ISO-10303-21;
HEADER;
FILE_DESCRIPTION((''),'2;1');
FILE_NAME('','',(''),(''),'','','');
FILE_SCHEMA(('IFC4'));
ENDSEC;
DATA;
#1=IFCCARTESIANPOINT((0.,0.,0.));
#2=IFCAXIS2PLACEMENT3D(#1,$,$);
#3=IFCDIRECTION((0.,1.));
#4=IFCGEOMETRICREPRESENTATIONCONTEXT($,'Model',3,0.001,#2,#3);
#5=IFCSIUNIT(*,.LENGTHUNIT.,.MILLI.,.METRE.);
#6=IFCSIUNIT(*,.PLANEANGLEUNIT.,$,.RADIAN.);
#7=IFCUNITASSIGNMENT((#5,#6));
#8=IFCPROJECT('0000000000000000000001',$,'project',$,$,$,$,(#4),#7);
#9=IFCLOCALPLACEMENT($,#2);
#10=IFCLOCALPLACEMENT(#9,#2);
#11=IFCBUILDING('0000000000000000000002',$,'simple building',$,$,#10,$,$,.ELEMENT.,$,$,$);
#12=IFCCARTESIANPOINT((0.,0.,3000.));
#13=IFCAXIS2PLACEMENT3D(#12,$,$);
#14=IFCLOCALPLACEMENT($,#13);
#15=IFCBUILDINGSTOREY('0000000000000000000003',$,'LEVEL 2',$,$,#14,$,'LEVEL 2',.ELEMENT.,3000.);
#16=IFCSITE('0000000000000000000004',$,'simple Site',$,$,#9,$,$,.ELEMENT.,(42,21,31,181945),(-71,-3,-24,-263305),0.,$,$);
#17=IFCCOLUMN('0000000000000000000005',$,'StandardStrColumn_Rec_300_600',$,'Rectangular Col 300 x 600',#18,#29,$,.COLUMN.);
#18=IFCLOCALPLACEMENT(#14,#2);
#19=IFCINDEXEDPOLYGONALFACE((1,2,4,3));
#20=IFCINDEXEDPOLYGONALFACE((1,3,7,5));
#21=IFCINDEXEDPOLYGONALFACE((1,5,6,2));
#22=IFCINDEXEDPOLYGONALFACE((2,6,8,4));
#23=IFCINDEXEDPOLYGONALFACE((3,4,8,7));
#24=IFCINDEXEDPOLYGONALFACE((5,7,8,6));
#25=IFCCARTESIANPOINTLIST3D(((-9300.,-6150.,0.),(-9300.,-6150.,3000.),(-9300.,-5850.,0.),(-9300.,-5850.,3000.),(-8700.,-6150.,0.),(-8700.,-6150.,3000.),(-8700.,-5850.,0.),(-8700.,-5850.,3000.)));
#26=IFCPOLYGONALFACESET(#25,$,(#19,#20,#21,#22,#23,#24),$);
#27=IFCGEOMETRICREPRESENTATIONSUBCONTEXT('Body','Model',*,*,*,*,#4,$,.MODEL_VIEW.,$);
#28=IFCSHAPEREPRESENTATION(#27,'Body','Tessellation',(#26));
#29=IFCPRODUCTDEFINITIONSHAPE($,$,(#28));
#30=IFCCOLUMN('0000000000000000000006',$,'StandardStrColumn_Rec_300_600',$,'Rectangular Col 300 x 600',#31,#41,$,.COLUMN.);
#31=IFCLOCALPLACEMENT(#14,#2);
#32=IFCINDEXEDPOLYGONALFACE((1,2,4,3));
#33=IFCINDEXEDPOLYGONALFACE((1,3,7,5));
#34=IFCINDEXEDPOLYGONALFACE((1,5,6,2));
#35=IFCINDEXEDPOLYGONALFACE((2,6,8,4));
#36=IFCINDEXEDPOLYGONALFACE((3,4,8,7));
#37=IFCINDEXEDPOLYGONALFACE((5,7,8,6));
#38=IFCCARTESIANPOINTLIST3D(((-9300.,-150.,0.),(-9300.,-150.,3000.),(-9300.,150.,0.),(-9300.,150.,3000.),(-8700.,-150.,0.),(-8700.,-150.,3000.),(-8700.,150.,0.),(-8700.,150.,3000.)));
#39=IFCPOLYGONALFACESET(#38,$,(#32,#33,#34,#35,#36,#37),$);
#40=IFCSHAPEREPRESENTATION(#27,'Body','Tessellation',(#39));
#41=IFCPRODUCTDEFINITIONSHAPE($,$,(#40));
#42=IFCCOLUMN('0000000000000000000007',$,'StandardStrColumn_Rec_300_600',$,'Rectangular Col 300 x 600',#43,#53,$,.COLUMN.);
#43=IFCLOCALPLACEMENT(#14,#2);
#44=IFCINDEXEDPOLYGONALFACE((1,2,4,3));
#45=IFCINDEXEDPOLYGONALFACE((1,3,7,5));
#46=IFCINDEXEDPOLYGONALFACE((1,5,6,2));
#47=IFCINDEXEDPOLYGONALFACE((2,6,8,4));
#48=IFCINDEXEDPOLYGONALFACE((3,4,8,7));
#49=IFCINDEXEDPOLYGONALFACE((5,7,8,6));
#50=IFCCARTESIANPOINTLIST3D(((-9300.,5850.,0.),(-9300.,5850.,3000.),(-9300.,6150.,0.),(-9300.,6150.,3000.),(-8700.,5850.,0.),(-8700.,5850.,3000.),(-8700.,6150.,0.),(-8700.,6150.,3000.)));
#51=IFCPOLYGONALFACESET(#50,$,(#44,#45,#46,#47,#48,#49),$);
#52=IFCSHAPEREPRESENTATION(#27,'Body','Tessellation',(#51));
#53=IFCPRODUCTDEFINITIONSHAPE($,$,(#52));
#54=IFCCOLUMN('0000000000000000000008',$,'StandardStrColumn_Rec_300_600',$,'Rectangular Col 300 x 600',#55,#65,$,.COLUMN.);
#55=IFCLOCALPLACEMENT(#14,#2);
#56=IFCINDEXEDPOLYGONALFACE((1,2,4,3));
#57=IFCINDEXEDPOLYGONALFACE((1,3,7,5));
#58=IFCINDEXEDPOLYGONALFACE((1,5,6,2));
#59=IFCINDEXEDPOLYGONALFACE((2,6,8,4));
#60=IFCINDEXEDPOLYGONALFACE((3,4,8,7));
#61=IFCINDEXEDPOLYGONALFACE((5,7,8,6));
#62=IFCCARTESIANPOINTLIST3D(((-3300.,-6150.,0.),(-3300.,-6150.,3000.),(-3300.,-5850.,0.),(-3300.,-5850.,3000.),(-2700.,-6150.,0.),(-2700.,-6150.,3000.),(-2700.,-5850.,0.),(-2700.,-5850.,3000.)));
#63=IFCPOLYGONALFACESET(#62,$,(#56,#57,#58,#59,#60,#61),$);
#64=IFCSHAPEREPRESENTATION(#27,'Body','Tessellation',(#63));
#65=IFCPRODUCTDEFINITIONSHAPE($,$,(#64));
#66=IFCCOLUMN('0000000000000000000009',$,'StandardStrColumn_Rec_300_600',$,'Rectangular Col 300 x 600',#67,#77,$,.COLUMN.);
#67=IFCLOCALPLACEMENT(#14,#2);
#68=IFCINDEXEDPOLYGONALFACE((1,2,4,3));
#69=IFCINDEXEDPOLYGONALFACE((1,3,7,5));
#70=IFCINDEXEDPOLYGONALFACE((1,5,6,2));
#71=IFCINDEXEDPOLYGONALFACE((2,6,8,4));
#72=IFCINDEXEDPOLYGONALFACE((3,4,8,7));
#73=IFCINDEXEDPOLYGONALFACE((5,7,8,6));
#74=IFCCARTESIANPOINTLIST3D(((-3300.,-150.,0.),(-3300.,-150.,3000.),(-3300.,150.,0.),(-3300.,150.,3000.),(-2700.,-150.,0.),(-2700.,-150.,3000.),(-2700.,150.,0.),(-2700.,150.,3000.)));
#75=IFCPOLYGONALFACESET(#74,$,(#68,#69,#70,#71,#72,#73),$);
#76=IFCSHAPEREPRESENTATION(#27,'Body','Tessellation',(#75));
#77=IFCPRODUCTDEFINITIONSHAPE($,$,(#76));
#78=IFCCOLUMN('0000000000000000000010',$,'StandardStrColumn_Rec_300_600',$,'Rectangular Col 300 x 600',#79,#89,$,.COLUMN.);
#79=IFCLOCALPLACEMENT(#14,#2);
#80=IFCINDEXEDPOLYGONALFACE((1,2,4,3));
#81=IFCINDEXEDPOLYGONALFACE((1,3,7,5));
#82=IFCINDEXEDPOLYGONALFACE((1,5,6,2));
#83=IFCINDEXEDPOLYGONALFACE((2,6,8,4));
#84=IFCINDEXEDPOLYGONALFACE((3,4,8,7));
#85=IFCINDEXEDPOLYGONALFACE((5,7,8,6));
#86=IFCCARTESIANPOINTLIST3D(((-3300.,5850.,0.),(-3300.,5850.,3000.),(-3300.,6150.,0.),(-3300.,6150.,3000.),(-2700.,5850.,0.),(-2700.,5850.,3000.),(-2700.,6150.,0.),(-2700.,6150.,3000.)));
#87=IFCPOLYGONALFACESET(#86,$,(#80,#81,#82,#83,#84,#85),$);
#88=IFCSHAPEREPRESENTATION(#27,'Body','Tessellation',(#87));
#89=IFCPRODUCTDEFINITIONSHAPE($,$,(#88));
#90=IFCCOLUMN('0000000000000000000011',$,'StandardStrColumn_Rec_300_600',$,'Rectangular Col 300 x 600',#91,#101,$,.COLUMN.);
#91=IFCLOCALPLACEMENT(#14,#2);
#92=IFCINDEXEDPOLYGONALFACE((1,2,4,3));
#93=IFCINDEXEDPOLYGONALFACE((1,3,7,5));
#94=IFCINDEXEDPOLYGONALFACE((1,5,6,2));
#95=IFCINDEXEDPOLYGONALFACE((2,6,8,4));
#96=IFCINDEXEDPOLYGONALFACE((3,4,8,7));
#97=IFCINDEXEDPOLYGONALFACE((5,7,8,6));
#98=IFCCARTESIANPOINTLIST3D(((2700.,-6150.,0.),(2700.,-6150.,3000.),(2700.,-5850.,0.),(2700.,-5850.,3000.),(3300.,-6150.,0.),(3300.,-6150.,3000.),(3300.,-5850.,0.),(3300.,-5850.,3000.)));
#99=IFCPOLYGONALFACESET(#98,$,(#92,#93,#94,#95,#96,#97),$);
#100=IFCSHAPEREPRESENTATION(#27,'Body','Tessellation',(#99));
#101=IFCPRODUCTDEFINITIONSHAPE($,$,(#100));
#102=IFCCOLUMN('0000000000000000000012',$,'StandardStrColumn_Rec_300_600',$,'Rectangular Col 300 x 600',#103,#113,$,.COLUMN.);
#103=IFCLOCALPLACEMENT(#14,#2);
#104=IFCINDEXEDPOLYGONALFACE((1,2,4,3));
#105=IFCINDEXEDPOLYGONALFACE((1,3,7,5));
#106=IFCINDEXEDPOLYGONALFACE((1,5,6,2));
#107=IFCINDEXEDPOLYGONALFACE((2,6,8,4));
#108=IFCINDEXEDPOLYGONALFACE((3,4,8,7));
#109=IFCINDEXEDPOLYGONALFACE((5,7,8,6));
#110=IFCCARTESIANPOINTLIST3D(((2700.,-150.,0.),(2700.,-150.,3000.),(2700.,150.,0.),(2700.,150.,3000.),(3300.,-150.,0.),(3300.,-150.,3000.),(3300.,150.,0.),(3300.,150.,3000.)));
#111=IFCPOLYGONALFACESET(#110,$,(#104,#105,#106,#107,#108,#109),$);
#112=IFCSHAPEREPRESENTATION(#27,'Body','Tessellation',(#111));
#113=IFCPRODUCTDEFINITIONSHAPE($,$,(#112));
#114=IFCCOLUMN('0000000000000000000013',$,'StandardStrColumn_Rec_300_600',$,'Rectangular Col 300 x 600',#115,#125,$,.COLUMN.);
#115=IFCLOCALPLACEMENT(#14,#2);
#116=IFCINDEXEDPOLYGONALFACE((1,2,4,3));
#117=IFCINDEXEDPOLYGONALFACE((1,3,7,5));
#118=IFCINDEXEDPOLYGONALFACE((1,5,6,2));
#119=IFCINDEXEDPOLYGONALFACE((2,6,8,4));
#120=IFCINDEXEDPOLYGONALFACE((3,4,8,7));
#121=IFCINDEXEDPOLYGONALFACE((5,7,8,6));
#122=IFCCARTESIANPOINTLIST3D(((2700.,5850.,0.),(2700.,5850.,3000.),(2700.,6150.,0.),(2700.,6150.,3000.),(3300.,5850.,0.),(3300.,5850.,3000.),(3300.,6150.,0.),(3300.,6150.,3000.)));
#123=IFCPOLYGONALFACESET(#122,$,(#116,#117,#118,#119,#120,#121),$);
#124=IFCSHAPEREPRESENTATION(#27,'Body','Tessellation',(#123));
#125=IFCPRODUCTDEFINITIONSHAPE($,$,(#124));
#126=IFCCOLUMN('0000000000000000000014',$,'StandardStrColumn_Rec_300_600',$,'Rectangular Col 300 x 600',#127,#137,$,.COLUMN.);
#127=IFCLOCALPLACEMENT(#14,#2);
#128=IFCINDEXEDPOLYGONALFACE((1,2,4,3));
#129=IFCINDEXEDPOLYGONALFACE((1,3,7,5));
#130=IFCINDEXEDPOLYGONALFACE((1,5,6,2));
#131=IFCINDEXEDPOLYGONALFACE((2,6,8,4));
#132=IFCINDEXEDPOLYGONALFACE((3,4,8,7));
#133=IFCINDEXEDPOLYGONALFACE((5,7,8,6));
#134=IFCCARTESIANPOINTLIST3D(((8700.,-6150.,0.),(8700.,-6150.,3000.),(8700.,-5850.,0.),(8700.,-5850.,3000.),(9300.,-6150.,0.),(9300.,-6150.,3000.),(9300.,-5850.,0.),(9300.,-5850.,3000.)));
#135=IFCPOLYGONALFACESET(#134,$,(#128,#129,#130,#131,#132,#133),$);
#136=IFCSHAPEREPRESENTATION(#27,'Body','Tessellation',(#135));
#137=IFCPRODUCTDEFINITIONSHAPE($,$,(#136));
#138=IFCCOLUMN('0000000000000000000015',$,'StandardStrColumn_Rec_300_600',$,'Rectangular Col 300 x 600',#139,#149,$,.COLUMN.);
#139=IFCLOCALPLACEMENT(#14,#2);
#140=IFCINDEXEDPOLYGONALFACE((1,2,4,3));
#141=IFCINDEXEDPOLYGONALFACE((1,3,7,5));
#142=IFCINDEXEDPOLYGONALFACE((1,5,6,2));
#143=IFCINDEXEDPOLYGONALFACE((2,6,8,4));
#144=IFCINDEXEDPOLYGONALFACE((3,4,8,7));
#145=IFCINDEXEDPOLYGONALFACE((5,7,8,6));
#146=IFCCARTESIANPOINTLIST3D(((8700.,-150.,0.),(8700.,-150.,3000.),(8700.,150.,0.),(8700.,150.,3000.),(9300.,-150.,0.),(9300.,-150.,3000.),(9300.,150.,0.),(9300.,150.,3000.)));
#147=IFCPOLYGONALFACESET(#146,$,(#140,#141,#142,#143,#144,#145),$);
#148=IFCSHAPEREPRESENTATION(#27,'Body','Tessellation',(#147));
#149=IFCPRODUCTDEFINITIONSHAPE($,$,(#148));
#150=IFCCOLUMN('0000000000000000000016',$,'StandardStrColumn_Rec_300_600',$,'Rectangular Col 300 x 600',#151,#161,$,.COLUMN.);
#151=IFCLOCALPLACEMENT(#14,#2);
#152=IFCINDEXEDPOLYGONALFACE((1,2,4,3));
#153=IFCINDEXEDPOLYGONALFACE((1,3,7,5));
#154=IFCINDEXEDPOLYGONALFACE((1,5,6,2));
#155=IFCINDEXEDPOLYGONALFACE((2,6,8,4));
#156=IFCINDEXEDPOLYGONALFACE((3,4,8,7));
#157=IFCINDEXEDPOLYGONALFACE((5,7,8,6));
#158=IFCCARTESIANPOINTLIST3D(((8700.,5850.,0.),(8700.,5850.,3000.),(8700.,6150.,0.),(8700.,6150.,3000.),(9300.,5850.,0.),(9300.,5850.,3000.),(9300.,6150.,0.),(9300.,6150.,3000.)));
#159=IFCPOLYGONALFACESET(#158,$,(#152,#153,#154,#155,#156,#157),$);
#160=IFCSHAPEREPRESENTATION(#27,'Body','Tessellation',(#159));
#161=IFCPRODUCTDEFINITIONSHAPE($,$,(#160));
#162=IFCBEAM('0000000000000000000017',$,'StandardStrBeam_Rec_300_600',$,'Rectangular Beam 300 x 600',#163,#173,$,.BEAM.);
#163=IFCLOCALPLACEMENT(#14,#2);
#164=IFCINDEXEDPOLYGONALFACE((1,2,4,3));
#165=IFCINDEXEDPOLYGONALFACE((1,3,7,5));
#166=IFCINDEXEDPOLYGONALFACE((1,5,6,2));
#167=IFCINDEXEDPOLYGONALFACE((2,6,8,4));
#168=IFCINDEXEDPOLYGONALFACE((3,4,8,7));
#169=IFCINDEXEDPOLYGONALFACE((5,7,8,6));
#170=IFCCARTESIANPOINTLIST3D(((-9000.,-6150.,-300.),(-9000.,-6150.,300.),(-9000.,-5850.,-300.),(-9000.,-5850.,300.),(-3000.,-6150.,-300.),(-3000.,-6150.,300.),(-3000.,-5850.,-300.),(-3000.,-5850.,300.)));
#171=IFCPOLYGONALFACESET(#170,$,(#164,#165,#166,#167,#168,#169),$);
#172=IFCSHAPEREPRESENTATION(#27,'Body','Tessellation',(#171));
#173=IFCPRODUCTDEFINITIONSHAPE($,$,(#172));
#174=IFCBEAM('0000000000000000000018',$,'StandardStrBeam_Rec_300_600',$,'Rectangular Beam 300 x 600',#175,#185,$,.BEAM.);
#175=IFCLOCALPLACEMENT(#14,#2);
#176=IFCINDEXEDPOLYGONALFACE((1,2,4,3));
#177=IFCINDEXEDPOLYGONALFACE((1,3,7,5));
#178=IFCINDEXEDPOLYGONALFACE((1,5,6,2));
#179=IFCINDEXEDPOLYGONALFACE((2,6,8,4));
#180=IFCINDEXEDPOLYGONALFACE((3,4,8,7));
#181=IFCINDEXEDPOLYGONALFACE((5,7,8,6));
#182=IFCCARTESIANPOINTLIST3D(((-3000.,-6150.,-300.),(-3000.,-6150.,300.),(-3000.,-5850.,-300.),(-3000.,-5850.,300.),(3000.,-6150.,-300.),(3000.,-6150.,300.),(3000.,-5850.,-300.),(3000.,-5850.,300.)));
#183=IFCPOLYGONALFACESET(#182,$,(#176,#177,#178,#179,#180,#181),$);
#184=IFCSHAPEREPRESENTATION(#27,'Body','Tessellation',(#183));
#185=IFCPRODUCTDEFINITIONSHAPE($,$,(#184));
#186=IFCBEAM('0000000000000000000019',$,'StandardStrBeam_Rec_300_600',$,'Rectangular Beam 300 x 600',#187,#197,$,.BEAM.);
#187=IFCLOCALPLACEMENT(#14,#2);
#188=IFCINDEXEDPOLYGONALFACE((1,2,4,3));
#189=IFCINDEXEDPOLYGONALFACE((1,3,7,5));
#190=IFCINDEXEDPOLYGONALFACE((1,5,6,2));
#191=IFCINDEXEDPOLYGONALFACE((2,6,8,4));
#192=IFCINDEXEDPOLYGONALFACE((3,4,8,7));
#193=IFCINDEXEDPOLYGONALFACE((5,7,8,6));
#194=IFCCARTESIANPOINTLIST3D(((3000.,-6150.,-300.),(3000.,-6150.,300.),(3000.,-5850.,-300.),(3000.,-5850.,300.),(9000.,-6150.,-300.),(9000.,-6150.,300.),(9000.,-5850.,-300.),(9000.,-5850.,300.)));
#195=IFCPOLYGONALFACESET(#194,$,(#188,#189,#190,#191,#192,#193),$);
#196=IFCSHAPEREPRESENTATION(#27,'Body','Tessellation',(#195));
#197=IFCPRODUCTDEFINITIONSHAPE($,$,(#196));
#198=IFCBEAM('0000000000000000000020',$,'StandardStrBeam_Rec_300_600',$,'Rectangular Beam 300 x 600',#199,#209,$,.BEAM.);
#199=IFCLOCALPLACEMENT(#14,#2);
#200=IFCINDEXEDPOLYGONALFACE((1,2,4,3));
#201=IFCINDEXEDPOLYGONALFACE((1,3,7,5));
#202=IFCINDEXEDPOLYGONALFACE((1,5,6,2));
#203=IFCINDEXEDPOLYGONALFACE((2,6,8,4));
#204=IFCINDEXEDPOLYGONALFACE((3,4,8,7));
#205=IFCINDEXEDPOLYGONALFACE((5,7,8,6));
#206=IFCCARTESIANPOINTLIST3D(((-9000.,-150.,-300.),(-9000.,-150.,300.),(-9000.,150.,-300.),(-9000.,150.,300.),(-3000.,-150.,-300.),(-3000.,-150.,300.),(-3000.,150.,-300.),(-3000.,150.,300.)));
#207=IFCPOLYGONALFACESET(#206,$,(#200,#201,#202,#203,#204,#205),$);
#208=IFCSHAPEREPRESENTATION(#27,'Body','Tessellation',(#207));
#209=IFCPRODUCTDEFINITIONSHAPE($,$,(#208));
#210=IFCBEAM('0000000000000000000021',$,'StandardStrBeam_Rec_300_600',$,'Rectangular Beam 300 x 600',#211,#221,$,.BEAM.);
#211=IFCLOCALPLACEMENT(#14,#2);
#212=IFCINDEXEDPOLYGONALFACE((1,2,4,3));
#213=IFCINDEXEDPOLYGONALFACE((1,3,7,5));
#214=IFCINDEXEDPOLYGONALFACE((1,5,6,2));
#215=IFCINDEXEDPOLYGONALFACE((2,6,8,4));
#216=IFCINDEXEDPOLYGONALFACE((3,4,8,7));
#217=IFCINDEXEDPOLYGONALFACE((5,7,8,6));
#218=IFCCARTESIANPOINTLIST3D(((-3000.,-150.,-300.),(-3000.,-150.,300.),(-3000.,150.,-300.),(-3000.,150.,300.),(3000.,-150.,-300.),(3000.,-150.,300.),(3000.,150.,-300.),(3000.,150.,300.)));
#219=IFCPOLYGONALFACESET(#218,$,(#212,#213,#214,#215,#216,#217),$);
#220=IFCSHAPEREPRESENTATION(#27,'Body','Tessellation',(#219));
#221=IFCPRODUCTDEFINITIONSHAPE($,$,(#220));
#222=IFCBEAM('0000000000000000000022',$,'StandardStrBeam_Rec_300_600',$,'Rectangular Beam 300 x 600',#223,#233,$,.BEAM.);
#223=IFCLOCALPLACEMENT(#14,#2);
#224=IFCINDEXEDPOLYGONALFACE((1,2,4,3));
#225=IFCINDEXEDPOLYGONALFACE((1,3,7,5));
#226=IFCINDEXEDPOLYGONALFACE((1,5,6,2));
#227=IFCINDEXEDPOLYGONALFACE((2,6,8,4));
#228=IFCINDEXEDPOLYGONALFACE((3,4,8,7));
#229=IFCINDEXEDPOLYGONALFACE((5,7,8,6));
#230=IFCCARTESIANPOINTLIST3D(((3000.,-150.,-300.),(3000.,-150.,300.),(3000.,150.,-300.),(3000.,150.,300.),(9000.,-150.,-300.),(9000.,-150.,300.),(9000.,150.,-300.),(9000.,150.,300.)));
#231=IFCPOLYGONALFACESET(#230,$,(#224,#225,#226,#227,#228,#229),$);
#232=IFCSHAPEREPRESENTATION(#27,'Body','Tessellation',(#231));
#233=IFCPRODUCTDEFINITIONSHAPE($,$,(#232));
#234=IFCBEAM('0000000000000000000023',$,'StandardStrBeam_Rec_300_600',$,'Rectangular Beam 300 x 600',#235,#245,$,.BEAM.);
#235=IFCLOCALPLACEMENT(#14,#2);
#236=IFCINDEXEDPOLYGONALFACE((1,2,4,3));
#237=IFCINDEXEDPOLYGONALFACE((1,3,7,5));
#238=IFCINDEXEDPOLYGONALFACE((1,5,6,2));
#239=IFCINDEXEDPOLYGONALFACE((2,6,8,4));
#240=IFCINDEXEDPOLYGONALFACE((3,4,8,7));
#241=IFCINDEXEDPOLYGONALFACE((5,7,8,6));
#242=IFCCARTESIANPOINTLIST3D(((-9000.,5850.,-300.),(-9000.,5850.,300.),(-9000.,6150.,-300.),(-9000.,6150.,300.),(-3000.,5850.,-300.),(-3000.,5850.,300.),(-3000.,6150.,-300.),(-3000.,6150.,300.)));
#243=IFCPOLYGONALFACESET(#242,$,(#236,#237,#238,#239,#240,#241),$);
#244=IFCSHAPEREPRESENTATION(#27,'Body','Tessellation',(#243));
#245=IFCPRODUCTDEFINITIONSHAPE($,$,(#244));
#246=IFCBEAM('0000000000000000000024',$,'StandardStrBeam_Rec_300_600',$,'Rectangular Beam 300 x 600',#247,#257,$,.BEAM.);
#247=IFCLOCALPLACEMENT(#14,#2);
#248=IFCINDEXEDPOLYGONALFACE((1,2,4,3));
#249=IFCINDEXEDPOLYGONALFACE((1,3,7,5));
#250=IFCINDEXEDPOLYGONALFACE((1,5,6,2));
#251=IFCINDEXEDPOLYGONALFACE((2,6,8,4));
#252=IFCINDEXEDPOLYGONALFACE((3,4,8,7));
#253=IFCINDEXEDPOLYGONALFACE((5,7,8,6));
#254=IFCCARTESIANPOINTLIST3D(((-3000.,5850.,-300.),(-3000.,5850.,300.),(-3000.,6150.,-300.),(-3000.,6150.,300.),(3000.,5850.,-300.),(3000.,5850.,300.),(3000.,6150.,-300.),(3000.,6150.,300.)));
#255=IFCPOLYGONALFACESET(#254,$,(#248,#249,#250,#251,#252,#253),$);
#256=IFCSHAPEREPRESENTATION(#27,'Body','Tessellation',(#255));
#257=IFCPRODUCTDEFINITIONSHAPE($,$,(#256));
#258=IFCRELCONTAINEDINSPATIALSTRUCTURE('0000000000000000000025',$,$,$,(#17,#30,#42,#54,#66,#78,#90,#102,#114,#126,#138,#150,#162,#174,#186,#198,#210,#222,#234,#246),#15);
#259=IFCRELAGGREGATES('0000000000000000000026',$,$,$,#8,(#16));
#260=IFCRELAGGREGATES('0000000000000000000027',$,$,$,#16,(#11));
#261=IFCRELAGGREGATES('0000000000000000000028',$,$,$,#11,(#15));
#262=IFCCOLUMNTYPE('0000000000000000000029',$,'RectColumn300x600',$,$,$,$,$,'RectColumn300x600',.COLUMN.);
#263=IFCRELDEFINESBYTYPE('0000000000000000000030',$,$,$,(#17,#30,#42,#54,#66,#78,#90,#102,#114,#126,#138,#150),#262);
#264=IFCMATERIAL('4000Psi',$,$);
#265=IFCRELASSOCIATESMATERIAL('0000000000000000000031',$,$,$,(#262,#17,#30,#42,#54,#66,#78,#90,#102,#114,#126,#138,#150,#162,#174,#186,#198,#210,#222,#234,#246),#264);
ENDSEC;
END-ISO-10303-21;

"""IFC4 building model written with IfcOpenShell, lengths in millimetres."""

from ifc_helpers import new_model, si_unit, direction, frame, origin, origin_with_axes, origin_2d_with_axis, place, context, subcontext, project, spatial, rectangle, extrude, material, material_profile, profile_set, profile_usage, type_object, element, save


model = new_model("IFC4")

# Units and contexts
model_context = context("Model", 3, precision=0.001, world=origin(), true_north=direction((0.0, 1.0)))
body_context = subcontext(model_context, "Body", "Model", "MODEL_VIEW")
ifc_project = project(units=[si_unit("LENGTHUNIT", "METRE", prefix="MILLI"), si_unit("PLANEANGLEUNIT", "RADIAN")], contexts=[model_context])

# Site, building, storey
site_placement = place(None, origin())
site = spatial("IfcSite", under=ifc_project, at=site_placement, Name="simple Site", CompositionType="ELEMENT", RefLatitude=(42, 21, 31, 181945), RefLongitude=(-71, -3, -24, -263305), RefElevation=0.0)
building_placement = place(site_placement, origin())
building = spatial("IfcBuilding", under=site, at=building_placement, Name="simple building", CompositionType="ELEMENT")
storey_placement = place(None, frame((0.0, 0.0, 3000.0)))
storey = spatial("IfcBuildingStorey", under=building, at=storey_placement, Name="LEVEL 2", LongName="LEVEL 2", CompositionType="ELEMENT", Elevation=3000.0)

# Columns
ifc_material_1 = material(Name="4000Psi")
ifc_material_profile = material_profile(ifc_material_1, rectangle(XDim=300.0, YDim=600.0, at=origin_2d_with_axis()))
ifc_profile_set = profile_set([ifc_material_profile])
ifc_profile_usage = profile_usage(ifc_profile_set, cardinal=10)
column_type = type_object("IfcColumnType", Name="RectColumn300x600", ElementType="RectColumn300x600", PredefinedType="COLUMN", material=ifc_profile_usage)
for number, where, z_axis, x_axis, name in (
    (1, (-9000.0, -6000.0, 3000.0), (0.0, 0.0, 1.0), (0.0, 1.0, 0.0), "StandardStrColumn_Rec_300_600"),
    (2, (-9000.0, 0.0, 3000.0), (0.0, 0.0, 1.0), (0.0, 1.0, 0.0), "StandardStrColumn_Rec_300_600"),
    (3, (-9000.0, 6000.0, 3000.0), (0.0, 0.0, 1.0), (0.0, 1.0, 0.0), "StandardStrColumn_Rec_300_600"),
    (4, (-3000.0, -6000.0, 3000.0), (0.0, 0.0, 1.0), (0.0, 1.0, 0.0), "StandardStrColumn_Rec_300_600"),
    (5, (-3000.0, 0.0, 3000.0), (0.0, 0.0, 1.0), (0.0, 1.0, 0.0), "StandardStrColumn_Rec_300_600"),
    (6, (-3000.0, 6000.0, 3000.0), (0.0, 0.0, 1.0), (0.0, 1.0, 0.0), "StandardStrColumn_Rec_300_600"),
    (7, (3000.0, -6000.0, 3000.0), (0.0, 0.0, 1.0), (0.0, 1.0, 0.0), "StandardStrColumn_Rec_300_600"),
    (8, (3000.0, 0.0, 3000.0), (0.0, 0.0, 1.0), (0.0, 1.0, 0.0), "StandardStrColumn_Rec_300_600"),
    (9, (3000.0, 6000.0, 3000.0), (0.0, 0.0, 1.0), (0.0, 1.0, 0.0), "StandardStrColumn_Rec_300_600"),
    (10, (9000.0, -6000.0, 3000.0), (0.0, 0.0, 1.0), (0.0, 1.0, 0.0), "StandardStrColumn_Rec_300_600"),
    (11, (9000.0, 0.0, 3000.0), (0.0, 0.0, 1.0), (0.0, 1.0, 0.0), "StandardStrColumn_Rec_300_600"),
    (12, (9000.0, 6000.0, 3000.0), (0.0, 0.0, 1.0), (0.0, 1.0, 0.0), "StandardStrColumn_Rec_300_600"),
):
    element("IfcColumn", number, at=place(None, frame(where, z_axis=z_axis, x_axis=x_axis)), inside=storey, type_object=column_type, material=ifc_profile_usage, Name=name, ObjectType="Rectangular Col 300 x 600", PredefinedType="COLUMN", context=body_context, shape_type="SweptSolid", body=[
        extrude(rectangle(XDim=300.0, YDim=600.0, at=origin_2d_with_axis()), origin_with_axes(), (0.0, 0.0, 1.0), 3000.0),
    ])

# Beams
for number, where, z_axis, x_axis, name in (
    (13, (-9000.0, -6000.0, 3000.0), (1.0, 0.0, 0.0), (0.0, -1.0, 0.0), "StandardStrBeam_Rec_300_600"),
    (14, (-3000.0, -6000.0, 3000.0), (1.0, 0.0, 0.0), (0.0, -1.0, 0.0), "StandardStrBeam_Rec_300_600"),
    (15, (3000.0, -6000.0, 3000.0), (1.0, 0.0, 0.0), (0.0, -1.0, 0.0), "StandardStrBeam_Rec_300_600"),
    (16, (-9000.0, 0.0, 3000.0), (1.0, 0.0, 0.0), (0.0, -1.0, 0.0), "StandardStrBeam_Rec_300_600"),
    (17, (-3000.0, 0.0, 3000.0), (1.0, 0.0, 0.0), (0.0, -1.0, 0.0), "StandardStrBeam_Rec_300_600"),
    (18, (3000.0, 0.0, 3000.0), (1.0, 0.0, 0.0), (0.0, -1.0, 0.0), "StandardStrBeam_Rec_300_600"),
    (19, (-9000.0, 6000.0, 3000.0), (1.0, 0.0, 0.0), (0.0, -1.0, 0.0), "StandardStrBeam_Rec_300_600"),
    (20, (-3000.0, 6000.0, 3000.0), (1.0, 0.0, 0.0), (0.0, -1.0, 0.0), "StandardStrBeam_Rec_300_600"),
):
    element("IfcBeam", number, at=place(None, frame(where, z_axis=z_axis, x_axis=x_axis)), inside=storey, material=ifc_profile_usage, Name=name, ObjectType="Rectangular Beam 300 x 600", PredefinedType="BEAM", context=body_context, shape_type="SweptSolid", body=[
        extrude(rectangle(XDim=300.0, YDim=600.0, at=origin_2d_with_axis()), origin_with_axes(), (0.0, 0.0, 1.0), 6000.0),
    ])

save(model, "model.ifc")
